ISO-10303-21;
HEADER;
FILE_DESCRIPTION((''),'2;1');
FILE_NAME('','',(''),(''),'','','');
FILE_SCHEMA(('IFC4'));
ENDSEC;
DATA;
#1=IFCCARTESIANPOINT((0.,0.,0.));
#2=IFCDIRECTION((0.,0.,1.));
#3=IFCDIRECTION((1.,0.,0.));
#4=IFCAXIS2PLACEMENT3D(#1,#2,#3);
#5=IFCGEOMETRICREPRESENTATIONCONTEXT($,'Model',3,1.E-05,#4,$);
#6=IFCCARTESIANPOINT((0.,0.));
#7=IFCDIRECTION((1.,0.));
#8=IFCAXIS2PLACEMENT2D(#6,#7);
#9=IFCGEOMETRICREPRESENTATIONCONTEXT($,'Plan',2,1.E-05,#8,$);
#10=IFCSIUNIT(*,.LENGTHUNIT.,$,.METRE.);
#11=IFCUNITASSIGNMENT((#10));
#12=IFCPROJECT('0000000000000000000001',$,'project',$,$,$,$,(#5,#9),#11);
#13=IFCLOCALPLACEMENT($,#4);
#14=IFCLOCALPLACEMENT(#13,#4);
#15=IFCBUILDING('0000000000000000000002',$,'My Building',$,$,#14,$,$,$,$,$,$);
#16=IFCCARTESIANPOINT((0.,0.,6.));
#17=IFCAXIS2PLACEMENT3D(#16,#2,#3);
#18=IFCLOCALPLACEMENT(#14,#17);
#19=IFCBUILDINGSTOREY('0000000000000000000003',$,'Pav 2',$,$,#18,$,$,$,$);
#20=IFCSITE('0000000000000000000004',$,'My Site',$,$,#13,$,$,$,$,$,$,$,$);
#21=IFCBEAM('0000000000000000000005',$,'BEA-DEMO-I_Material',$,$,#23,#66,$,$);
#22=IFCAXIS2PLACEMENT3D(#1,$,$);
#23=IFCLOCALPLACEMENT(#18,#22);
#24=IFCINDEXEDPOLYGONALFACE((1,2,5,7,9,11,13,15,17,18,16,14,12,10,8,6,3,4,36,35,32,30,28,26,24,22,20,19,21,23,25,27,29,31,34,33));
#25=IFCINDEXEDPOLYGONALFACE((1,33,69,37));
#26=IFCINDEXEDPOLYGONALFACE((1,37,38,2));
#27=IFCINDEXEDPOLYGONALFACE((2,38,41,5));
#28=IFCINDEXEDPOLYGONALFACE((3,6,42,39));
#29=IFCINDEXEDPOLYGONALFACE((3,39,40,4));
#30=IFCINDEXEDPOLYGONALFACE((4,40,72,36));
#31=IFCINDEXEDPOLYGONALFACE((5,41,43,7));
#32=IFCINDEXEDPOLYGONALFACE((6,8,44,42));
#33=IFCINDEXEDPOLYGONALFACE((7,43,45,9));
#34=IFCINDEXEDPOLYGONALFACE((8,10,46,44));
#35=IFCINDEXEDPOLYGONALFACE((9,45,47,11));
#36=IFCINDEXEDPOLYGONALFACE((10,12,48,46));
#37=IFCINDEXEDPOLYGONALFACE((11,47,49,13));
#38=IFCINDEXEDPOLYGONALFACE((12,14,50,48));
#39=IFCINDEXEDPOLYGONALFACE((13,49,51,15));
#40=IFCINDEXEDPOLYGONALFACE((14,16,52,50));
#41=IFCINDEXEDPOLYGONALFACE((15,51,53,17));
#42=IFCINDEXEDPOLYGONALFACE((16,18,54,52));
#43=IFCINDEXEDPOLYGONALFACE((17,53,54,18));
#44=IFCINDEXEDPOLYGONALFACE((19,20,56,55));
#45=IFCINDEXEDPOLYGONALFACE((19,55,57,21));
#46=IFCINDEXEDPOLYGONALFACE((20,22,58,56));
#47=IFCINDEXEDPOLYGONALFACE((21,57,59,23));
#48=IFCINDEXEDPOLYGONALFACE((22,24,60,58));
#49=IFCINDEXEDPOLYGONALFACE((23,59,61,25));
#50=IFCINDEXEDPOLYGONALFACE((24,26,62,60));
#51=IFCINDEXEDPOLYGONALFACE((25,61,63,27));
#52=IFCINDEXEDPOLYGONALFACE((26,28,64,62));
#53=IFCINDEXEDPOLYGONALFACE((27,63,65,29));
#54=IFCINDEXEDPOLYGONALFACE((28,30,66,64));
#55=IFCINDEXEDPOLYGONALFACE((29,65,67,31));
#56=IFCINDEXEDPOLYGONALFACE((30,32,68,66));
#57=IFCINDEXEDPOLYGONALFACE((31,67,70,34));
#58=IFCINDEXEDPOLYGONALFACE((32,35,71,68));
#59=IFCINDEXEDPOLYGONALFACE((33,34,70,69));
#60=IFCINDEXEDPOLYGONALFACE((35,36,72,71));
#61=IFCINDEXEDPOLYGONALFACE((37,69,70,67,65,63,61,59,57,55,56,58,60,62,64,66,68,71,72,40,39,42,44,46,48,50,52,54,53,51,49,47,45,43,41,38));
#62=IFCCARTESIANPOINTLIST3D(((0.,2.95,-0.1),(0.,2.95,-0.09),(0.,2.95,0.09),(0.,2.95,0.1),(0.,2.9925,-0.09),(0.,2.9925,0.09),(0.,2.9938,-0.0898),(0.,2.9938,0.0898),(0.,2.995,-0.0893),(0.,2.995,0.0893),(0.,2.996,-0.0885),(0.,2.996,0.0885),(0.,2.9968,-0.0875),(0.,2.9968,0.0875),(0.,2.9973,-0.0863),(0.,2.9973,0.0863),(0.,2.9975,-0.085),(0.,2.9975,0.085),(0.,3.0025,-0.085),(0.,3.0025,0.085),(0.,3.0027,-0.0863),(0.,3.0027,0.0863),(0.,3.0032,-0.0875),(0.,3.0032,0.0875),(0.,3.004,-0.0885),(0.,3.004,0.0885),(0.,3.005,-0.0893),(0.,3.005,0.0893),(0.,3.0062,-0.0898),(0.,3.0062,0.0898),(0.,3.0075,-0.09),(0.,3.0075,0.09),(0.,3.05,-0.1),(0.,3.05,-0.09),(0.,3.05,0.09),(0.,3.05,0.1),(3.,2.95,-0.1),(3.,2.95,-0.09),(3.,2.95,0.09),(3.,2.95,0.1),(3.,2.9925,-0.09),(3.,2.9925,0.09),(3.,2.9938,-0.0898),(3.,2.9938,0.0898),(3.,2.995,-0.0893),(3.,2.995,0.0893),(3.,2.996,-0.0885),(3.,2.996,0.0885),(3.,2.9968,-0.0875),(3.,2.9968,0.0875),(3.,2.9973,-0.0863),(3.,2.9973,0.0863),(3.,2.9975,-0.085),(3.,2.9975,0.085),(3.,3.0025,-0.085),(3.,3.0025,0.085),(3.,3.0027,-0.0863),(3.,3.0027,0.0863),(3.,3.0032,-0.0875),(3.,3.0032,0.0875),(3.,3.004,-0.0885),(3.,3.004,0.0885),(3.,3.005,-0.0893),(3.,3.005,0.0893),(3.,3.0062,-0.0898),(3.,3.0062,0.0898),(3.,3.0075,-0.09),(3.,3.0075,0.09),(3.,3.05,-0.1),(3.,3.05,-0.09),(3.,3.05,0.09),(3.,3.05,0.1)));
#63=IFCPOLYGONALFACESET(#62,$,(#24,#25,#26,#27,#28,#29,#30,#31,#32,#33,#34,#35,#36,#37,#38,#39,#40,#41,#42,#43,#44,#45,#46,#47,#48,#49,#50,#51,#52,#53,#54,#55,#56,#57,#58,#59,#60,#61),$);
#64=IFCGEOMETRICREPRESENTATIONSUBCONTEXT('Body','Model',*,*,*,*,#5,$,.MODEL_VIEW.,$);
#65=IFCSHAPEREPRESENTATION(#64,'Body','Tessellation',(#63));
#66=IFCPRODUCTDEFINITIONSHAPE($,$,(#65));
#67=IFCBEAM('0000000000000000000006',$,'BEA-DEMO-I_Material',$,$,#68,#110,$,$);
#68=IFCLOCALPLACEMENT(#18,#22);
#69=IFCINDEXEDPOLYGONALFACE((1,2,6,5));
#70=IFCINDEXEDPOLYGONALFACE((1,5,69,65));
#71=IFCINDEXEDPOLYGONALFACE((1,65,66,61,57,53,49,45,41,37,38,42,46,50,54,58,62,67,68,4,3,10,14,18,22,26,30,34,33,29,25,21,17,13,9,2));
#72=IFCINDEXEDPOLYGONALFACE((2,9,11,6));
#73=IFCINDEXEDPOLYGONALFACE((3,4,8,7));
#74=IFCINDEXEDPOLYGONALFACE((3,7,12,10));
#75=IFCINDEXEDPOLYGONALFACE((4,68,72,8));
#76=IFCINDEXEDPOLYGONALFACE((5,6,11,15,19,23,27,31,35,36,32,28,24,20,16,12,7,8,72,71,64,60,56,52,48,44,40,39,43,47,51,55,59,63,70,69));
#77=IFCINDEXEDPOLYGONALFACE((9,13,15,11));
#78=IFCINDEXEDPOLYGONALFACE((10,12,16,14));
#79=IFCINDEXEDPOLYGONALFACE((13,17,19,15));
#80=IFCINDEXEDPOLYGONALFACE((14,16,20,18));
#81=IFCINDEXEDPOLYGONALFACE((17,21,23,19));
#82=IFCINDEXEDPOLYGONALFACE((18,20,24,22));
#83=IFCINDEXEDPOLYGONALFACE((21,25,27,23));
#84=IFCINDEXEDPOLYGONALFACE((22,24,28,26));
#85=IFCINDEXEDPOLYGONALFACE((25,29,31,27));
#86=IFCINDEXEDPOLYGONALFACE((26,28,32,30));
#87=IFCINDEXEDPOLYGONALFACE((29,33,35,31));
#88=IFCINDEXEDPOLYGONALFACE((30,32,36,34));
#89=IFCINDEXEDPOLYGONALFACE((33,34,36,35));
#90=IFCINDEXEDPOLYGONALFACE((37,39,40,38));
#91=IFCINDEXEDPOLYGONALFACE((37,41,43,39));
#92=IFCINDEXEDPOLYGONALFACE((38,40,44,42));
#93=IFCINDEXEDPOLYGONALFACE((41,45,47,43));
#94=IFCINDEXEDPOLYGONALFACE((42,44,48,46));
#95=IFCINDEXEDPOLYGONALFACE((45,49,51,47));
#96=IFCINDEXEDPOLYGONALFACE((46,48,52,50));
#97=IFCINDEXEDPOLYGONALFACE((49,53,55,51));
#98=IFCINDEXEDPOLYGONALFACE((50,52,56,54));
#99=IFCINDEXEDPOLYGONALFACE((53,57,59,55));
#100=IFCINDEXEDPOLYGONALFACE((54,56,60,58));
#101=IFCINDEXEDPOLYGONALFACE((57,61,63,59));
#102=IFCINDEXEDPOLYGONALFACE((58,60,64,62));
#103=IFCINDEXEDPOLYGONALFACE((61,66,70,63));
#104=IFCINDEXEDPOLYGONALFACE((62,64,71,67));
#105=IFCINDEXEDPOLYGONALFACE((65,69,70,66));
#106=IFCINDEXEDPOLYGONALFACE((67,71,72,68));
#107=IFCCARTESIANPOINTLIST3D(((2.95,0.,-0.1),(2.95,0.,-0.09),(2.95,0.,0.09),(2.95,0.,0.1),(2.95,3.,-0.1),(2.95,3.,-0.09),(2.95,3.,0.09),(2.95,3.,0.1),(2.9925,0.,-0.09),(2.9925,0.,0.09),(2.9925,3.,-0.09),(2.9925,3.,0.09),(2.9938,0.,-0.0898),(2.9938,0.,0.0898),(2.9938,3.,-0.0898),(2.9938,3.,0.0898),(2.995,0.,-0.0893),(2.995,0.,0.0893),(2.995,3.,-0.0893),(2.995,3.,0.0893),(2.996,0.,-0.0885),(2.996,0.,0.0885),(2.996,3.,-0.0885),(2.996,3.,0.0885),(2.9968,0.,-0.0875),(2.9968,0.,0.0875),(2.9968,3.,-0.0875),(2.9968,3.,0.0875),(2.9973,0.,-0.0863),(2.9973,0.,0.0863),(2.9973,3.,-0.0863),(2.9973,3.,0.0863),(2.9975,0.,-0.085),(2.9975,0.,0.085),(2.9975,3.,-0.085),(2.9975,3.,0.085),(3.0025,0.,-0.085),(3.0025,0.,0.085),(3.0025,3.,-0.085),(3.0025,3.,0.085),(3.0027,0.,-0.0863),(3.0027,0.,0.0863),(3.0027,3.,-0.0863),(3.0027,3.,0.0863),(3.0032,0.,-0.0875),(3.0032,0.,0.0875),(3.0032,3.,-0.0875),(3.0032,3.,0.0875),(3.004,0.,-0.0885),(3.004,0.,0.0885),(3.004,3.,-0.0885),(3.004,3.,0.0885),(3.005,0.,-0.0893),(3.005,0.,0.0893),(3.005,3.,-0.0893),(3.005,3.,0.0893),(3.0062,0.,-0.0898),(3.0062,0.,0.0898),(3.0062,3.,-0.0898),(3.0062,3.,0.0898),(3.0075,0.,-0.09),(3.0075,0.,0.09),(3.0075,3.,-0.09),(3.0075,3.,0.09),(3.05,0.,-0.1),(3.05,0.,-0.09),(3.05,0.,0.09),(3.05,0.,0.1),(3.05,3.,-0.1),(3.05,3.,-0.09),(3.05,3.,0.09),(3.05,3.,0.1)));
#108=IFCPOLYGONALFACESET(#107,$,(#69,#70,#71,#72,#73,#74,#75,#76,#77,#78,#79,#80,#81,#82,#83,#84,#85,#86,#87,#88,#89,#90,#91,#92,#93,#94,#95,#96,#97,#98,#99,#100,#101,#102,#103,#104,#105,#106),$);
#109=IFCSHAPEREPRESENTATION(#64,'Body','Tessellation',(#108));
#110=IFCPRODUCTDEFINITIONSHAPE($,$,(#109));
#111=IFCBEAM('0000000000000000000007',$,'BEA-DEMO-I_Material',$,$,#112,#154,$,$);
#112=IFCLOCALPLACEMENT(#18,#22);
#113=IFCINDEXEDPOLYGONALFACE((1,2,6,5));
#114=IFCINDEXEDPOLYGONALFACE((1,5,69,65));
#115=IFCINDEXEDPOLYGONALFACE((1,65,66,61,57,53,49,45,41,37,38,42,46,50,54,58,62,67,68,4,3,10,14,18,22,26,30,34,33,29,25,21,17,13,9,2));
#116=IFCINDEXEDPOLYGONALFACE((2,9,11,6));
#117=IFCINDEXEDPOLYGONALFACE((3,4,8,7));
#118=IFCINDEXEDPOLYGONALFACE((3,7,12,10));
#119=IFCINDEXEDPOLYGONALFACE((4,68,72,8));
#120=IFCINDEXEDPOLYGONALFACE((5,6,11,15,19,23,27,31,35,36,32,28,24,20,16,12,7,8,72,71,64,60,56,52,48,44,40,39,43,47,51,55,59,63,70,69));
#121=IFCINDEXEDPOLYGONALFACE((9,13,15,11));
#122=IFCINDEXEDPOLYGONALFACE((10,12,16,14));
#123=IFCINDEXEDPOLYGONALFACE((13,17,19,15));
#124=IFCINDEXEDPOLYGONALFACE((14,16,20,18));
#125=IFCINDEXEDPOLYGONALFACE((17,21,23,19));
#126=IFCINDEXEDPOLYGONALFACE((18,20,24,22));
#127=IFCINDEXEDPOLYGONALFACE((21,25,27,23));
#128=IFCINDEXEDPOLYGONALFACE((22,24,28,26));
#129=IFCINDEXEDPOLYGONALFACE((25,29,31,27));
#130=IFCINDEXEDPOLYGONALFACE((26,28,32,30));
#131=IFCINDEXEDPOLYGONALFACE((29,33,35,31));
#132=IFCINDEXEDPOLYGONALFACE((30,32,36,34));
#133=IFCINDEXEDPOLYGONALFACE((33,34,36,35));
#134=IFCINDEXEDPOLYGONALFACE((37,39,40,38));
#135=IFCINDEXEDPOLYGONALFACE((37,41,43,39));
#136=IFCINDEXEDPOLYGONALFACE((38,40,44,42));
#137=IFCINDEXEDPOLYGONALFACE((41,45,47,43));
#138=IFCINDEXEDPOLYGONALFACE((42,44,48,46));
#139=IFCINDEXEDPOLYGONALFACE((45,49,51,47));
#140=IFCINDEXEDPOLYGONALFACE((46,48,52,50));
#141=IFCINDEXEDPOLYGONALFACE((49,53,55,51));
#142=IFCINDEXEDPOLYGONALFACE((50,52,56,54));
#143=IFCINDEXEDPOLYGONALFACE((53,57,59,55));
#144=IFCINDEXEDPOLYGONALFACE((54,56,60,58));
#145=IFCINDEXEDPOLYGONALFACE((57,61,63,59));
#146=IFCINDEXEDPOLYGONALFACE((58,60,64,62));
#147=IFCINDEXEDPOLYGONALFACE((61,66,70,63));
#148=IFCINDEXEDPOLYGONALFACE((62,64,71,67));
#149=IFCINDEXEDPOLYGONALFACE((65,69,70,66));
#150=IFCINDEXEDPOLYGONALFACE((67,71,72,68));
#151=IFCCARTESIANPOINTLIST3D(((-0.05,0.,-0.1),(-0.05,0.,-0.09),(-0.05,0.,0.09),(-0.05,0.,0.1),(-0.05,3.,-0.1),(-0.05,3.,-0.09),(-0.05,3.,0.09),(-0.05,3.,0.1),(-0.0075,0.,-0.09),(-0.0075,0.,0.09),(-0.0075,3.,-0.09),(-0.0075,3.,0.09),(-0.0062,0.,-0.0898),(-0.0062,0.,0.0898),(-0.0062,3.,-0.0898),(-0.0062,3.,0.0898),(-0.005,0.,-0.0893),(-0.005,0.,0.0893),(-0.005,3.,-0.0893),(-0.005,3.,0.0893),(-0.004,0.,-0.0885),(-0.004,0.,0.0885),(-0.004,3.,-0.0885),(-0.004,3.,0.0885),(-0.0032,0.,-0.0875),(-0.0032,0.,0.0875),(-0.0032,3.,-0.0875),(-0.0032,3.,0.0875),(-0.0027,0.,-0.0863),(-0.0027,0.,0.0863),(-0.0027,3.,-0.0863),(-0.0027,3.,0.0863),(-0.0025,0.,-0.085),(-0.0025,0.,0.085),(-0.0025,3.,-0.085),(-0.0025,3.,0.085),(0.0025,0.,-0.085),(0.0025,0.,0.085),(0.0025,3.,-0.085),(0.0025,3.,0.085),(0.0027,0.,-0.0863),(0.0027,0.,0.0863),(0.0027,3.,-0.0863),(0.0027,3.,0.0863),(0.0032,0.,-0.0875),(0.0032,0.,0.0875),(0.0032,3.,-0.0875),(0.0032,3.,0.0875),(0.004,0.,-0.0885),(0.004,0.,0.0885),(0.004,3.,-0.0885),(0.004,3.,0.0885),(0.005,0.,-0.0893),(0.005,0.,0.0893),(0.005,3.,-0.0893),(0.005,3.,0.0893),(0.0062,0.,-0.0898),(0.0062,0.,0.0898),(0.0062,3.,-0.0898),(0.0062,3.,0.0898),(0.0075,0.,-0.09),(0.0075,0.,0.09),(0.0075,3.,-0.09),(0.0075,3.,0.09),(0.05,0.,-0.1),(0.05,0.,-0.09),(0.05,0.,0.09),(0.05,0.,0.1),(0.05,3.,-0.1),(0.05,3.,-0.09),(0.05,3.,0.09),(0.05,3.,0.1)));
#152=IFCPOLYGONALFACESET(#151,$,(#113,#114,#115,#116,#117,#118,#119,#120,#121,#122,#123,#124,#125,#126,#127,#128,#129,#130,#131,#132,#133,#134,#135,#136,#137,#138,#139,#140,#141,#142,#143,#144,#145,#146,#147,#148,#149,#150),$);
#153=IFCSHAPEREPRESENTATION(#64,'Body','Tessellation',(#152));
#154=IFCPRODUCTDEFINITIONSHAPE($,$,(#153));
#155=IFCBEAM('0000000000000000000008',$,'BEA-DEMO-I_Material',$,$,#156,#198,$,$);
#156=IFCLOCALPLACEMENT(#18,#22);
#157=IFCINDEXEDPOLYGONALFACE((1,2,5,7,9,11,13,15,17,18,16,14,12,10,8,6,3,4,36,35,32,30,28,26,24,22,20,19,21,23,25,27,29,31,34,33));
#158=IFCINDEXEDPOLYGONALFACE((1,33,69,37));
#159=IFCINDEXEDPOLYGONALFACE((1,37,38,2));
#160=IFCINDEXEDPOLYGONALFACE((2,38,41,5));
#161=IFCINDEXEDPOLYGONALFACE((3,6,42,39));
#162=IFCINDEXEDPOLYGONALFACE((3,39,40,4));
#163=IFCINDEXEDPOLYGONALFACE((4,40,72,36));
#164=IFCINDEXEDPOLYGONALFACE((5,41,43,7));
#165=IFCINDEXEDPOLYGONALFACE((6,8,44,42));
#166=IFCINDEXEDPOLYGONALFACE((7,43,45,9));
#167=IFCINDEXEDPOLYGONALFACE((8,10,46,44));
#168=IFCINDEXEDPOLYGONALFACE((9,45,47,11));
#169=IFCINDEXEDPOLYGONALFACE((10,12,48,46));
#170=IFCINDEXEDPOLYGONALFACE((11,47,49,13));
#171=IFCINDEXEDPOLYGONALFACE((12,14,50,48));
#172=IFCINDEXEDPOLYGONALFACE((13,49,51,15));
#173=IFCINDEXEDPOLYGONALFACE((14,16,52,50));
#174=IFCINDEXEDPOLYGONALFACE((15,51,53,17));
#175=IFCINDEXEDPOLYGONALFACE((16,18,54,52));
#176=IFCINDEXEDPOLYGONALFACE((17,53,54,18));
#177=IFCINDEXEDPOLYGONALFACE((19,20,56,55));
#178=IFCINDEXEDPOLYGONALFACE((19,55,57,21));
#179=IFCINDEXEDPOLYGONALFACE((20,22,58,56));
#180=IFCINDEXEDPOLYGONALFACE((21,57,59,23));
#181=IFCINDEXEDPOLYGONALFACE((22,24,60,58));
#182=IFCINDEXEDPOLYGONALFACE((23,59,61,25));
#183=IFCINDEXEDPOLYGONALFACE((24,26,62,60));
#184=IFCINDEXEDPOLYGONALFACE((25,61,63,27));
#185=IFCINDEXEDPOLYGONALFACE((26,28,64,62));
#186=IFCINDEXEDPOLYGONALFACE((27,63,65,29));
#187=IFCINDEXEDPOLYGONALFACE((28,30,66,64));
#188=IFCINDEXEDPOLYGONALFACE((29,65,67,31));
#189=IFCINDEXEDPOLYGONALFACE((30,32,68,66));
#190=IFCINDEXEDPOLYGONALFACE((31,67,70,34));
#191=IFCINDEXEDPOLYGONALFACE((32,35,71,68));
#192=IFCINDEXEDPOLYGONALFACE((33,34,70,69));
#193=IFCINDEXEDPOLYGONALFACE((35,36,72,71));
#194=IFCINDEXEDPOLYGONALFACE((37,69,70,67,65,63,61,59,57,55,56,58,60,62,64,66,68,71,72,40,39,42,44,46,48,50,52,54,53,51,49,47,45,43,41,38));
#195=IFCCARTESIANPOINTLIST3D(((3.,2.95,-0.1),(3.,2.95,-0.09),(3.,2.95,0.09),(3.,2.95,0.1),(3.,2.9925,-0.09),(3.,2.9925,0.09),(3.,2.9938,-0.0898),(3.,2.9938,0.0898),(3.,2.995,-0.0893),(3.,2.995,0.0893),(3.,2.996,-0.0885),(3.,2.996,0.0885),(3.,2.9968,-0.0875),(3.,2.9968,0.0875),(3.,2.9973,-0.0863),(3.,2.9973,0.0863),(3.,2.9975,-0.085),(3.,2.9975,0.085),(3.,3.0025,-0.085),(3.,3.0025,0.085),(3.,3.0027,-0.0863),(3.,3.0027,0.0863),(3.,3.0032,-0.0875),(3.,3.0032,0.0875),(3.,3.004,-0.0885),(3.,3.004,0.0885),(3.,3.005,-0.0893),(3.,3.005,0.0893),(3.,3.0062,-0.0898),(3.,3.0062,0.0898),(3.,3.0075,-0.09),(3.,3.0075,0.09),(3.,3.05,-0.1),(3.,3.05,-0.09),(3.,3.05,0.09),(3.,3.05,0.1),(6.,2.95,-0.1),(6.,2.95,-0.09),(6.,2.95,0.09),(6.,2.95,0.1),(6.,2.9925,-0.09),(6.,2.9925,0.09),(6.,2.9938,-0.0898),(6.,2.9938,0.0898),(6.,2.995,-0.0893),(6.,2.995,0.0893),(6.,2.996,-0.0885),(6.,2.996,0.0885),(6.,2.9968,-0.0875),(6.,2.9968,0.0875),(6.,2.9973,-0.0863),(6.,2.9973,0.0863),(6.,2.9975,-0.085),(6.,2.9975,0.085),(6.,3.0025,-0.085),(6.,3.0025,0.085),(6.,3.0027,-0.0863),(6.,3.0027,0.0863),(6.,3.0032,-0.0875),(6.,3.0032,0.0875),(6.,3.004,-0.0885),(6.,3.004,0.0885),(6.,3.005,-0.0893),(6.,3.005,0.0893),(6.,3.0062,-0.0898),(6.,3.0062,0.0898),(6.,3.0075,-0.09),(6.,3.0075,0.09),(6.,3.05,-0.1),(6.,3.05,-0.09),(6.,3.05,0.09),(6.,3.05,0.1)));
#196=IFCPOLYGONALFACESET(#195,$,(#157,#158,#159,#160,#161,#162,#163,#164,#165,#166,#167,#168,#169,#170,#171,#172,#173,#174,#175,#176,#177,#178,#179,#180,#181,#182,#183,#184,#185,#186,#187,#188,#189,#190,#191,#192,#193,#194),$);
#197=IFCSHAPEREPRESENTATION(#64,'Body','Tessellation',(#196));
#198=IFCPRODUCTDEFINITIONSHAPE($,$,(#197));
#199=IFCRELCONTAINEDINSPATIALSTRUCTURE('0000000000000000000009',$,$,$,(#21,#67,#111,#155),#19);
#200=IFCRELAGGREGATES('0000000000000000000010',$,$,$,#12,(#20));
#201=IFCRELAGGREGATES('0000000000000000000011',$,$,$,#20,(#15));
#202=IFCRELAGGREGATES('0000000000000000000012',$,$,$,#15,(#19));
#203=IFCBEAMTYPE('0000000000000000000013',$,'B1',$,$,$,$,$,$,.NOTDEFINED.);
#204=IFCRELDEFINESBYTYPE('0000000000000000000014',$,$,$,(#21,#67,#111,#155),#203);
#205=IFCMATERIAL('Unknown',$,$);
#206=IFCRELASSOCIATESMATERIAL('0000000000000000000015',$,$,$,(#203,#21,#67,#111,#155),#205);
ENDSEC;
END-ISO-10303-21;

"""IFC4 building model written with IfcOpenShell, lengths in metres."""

from ifc_helpers import new_model, si_unit, frame, origin, origin_with_axes, origin_2d_with_axis, place, context, subcontext, project, spatial, i_section, extrude, material, material_profile, profile_set, profile_usage, type_object, element, save


model = new_model("IFC4")

# Units and contexts
model_context = context("Model", 3, precision=1e-05, world=origin_with_axes())
plan_context = context("Plan", 2, precision=1e-05, world=origin_2d_with_axis())
body_context = subcontext(model_context, "Body", "Model", "MODEL_VIEW")
ifc_project = project(units=[si_unit("LENGTHUNIT", "METRE")], contexts=[model_context, plan_context])

# Site, building, storey
site_placement = place(None, origin_with_axes())
site = spatial("IfcSite", under=ifc_project, at=site_placement, Name="My Site")
building_placement = place(site_placement, origin_with_axes())
building = spatial("IfcBuilding", under=site, at=building_placement, Name="My Building")
storey_placement = place(building_placement, frame((0.0, 0.0, 6.0), z_axis=(0.0, 0.0, 1.0), x_axis=(1.0, 0.0, 0.0)))
storey = spatial("IfcBuildingStorey", under=building, at=storey_placement, Name="Pav 2")

# Beams
ifc_material = material(Name="Unknown")
ifc_material_profile = material_profile(ifc_material, i_section(OverallWidth=0.1, OverallDepth=0.2, WebThickness=0.005, FlangeThickness=0.01, FilletRadius=0.005))
ifc_profile_set = profile_set([ifc_material_profile])
beam_type = type_object("IfcBeamType", Name="B1", PredefinedType="NOTDEFINED", material=ifc_profile_set)
ifc_profile_usage_1 = profile_usage(ifc_profile_set, cardinal=5)
beam_1_placement = place(storey_placement, frame((0.0, 3.0, 0.0), z_axis=(1.0, 0.0, 0.0), x_axis=(0.0, 1.0, 0.0)))
element("IfcBeam", 1, at=beam_1_placement, inside=storey, type_object=beam_type, material=ifc_profile_usage_1, Name="BEA-DEMO-I_Material", context=body_context, shape_type="SweptSolid", body=[
    extrude(i_section(OverallWidth=0.1, OverallDepth=0.2, WebThickness=0.005, FlangeThickness=0.01, FilletRadius=0.005), origin(), (0.0, 0.0, 1.0), 3.0),
])
ifc_profile_usage_2 = profile_usage(ifc_profile_set, cardinal=5)
beam_2_placement = place(storey_placement, frame((3.0, 3.0, 0.0), z_axis=(0.0, -1.0, 0.0), x_axis=(1.0, 0.0, 0.0)))
element("IfcBeam", 2, at=beam_2_placement, inside=storey, type_object=beam_type, material=ifc_profile_usage_2, Name="BEA-DEMO-I_Material", context=body_context, shape_type="SweptSolid", body=[
    extrude(i_section(OverallWidth=0.1, OverallDepth=0.2, WebThickness=0.005, FlangeThickness=0.01, FilletRadius=0.005), origin(), (0.0, 0.0, 1.0), 3.0),
])
ifc_profile_usage_3 = profile_usage(ifc_profile_set, cardinal=5)
beam_3_placement = place(storey_placement, frame((0.0, 0.0, 0.0), z_axis=(0.0, 1.0, 0.0), x_axis=(-1.0, 0.0, 0.0)))
element("IfcBeam", 3, at=beam_3_placement, inside=storey, type_object=beam_type, material=ifc_profile_usage_3, Name="BEA-DEMO-I_Material", context=body_context, shape_type="SweptSolid", body=[
    extrude(i_section(OverallWidth=0.1, OverallDepth=0.2, WebThickness=0.005, FlangeThickness=0.01, FilletRadius=0.005), origin(), (0.0, 0.0, 1.0), 3.0),
])
ifc_profile_usage_4 = profile_usage(ifc_profile_set, cardinal=5)
beam_4_placement = place(storey_placement, frame((3.0, 3.0, 0.0), z_axis=(1.0, 0.0, 0.0), x_axis=(0.0, 1.0, 0.0)))
element("IfcBeam", 4, at=beam_4_placement, inside=storey, type_object=beam_type, material=ifc_profile_usage_4, Name="BEA-DEMO-I_Material", context=body_context, shape_type="SweptSolid", body=[
    extrude(i_section(OverallWidth=0.1, OverallDepth=0.2, WebThickness=0.005, FlangeThickness=0.01, FilletRadius=0.005), origin(), (0.0, 0.0, 1.0), 3.0),
])

save(model, "model.ifc")
